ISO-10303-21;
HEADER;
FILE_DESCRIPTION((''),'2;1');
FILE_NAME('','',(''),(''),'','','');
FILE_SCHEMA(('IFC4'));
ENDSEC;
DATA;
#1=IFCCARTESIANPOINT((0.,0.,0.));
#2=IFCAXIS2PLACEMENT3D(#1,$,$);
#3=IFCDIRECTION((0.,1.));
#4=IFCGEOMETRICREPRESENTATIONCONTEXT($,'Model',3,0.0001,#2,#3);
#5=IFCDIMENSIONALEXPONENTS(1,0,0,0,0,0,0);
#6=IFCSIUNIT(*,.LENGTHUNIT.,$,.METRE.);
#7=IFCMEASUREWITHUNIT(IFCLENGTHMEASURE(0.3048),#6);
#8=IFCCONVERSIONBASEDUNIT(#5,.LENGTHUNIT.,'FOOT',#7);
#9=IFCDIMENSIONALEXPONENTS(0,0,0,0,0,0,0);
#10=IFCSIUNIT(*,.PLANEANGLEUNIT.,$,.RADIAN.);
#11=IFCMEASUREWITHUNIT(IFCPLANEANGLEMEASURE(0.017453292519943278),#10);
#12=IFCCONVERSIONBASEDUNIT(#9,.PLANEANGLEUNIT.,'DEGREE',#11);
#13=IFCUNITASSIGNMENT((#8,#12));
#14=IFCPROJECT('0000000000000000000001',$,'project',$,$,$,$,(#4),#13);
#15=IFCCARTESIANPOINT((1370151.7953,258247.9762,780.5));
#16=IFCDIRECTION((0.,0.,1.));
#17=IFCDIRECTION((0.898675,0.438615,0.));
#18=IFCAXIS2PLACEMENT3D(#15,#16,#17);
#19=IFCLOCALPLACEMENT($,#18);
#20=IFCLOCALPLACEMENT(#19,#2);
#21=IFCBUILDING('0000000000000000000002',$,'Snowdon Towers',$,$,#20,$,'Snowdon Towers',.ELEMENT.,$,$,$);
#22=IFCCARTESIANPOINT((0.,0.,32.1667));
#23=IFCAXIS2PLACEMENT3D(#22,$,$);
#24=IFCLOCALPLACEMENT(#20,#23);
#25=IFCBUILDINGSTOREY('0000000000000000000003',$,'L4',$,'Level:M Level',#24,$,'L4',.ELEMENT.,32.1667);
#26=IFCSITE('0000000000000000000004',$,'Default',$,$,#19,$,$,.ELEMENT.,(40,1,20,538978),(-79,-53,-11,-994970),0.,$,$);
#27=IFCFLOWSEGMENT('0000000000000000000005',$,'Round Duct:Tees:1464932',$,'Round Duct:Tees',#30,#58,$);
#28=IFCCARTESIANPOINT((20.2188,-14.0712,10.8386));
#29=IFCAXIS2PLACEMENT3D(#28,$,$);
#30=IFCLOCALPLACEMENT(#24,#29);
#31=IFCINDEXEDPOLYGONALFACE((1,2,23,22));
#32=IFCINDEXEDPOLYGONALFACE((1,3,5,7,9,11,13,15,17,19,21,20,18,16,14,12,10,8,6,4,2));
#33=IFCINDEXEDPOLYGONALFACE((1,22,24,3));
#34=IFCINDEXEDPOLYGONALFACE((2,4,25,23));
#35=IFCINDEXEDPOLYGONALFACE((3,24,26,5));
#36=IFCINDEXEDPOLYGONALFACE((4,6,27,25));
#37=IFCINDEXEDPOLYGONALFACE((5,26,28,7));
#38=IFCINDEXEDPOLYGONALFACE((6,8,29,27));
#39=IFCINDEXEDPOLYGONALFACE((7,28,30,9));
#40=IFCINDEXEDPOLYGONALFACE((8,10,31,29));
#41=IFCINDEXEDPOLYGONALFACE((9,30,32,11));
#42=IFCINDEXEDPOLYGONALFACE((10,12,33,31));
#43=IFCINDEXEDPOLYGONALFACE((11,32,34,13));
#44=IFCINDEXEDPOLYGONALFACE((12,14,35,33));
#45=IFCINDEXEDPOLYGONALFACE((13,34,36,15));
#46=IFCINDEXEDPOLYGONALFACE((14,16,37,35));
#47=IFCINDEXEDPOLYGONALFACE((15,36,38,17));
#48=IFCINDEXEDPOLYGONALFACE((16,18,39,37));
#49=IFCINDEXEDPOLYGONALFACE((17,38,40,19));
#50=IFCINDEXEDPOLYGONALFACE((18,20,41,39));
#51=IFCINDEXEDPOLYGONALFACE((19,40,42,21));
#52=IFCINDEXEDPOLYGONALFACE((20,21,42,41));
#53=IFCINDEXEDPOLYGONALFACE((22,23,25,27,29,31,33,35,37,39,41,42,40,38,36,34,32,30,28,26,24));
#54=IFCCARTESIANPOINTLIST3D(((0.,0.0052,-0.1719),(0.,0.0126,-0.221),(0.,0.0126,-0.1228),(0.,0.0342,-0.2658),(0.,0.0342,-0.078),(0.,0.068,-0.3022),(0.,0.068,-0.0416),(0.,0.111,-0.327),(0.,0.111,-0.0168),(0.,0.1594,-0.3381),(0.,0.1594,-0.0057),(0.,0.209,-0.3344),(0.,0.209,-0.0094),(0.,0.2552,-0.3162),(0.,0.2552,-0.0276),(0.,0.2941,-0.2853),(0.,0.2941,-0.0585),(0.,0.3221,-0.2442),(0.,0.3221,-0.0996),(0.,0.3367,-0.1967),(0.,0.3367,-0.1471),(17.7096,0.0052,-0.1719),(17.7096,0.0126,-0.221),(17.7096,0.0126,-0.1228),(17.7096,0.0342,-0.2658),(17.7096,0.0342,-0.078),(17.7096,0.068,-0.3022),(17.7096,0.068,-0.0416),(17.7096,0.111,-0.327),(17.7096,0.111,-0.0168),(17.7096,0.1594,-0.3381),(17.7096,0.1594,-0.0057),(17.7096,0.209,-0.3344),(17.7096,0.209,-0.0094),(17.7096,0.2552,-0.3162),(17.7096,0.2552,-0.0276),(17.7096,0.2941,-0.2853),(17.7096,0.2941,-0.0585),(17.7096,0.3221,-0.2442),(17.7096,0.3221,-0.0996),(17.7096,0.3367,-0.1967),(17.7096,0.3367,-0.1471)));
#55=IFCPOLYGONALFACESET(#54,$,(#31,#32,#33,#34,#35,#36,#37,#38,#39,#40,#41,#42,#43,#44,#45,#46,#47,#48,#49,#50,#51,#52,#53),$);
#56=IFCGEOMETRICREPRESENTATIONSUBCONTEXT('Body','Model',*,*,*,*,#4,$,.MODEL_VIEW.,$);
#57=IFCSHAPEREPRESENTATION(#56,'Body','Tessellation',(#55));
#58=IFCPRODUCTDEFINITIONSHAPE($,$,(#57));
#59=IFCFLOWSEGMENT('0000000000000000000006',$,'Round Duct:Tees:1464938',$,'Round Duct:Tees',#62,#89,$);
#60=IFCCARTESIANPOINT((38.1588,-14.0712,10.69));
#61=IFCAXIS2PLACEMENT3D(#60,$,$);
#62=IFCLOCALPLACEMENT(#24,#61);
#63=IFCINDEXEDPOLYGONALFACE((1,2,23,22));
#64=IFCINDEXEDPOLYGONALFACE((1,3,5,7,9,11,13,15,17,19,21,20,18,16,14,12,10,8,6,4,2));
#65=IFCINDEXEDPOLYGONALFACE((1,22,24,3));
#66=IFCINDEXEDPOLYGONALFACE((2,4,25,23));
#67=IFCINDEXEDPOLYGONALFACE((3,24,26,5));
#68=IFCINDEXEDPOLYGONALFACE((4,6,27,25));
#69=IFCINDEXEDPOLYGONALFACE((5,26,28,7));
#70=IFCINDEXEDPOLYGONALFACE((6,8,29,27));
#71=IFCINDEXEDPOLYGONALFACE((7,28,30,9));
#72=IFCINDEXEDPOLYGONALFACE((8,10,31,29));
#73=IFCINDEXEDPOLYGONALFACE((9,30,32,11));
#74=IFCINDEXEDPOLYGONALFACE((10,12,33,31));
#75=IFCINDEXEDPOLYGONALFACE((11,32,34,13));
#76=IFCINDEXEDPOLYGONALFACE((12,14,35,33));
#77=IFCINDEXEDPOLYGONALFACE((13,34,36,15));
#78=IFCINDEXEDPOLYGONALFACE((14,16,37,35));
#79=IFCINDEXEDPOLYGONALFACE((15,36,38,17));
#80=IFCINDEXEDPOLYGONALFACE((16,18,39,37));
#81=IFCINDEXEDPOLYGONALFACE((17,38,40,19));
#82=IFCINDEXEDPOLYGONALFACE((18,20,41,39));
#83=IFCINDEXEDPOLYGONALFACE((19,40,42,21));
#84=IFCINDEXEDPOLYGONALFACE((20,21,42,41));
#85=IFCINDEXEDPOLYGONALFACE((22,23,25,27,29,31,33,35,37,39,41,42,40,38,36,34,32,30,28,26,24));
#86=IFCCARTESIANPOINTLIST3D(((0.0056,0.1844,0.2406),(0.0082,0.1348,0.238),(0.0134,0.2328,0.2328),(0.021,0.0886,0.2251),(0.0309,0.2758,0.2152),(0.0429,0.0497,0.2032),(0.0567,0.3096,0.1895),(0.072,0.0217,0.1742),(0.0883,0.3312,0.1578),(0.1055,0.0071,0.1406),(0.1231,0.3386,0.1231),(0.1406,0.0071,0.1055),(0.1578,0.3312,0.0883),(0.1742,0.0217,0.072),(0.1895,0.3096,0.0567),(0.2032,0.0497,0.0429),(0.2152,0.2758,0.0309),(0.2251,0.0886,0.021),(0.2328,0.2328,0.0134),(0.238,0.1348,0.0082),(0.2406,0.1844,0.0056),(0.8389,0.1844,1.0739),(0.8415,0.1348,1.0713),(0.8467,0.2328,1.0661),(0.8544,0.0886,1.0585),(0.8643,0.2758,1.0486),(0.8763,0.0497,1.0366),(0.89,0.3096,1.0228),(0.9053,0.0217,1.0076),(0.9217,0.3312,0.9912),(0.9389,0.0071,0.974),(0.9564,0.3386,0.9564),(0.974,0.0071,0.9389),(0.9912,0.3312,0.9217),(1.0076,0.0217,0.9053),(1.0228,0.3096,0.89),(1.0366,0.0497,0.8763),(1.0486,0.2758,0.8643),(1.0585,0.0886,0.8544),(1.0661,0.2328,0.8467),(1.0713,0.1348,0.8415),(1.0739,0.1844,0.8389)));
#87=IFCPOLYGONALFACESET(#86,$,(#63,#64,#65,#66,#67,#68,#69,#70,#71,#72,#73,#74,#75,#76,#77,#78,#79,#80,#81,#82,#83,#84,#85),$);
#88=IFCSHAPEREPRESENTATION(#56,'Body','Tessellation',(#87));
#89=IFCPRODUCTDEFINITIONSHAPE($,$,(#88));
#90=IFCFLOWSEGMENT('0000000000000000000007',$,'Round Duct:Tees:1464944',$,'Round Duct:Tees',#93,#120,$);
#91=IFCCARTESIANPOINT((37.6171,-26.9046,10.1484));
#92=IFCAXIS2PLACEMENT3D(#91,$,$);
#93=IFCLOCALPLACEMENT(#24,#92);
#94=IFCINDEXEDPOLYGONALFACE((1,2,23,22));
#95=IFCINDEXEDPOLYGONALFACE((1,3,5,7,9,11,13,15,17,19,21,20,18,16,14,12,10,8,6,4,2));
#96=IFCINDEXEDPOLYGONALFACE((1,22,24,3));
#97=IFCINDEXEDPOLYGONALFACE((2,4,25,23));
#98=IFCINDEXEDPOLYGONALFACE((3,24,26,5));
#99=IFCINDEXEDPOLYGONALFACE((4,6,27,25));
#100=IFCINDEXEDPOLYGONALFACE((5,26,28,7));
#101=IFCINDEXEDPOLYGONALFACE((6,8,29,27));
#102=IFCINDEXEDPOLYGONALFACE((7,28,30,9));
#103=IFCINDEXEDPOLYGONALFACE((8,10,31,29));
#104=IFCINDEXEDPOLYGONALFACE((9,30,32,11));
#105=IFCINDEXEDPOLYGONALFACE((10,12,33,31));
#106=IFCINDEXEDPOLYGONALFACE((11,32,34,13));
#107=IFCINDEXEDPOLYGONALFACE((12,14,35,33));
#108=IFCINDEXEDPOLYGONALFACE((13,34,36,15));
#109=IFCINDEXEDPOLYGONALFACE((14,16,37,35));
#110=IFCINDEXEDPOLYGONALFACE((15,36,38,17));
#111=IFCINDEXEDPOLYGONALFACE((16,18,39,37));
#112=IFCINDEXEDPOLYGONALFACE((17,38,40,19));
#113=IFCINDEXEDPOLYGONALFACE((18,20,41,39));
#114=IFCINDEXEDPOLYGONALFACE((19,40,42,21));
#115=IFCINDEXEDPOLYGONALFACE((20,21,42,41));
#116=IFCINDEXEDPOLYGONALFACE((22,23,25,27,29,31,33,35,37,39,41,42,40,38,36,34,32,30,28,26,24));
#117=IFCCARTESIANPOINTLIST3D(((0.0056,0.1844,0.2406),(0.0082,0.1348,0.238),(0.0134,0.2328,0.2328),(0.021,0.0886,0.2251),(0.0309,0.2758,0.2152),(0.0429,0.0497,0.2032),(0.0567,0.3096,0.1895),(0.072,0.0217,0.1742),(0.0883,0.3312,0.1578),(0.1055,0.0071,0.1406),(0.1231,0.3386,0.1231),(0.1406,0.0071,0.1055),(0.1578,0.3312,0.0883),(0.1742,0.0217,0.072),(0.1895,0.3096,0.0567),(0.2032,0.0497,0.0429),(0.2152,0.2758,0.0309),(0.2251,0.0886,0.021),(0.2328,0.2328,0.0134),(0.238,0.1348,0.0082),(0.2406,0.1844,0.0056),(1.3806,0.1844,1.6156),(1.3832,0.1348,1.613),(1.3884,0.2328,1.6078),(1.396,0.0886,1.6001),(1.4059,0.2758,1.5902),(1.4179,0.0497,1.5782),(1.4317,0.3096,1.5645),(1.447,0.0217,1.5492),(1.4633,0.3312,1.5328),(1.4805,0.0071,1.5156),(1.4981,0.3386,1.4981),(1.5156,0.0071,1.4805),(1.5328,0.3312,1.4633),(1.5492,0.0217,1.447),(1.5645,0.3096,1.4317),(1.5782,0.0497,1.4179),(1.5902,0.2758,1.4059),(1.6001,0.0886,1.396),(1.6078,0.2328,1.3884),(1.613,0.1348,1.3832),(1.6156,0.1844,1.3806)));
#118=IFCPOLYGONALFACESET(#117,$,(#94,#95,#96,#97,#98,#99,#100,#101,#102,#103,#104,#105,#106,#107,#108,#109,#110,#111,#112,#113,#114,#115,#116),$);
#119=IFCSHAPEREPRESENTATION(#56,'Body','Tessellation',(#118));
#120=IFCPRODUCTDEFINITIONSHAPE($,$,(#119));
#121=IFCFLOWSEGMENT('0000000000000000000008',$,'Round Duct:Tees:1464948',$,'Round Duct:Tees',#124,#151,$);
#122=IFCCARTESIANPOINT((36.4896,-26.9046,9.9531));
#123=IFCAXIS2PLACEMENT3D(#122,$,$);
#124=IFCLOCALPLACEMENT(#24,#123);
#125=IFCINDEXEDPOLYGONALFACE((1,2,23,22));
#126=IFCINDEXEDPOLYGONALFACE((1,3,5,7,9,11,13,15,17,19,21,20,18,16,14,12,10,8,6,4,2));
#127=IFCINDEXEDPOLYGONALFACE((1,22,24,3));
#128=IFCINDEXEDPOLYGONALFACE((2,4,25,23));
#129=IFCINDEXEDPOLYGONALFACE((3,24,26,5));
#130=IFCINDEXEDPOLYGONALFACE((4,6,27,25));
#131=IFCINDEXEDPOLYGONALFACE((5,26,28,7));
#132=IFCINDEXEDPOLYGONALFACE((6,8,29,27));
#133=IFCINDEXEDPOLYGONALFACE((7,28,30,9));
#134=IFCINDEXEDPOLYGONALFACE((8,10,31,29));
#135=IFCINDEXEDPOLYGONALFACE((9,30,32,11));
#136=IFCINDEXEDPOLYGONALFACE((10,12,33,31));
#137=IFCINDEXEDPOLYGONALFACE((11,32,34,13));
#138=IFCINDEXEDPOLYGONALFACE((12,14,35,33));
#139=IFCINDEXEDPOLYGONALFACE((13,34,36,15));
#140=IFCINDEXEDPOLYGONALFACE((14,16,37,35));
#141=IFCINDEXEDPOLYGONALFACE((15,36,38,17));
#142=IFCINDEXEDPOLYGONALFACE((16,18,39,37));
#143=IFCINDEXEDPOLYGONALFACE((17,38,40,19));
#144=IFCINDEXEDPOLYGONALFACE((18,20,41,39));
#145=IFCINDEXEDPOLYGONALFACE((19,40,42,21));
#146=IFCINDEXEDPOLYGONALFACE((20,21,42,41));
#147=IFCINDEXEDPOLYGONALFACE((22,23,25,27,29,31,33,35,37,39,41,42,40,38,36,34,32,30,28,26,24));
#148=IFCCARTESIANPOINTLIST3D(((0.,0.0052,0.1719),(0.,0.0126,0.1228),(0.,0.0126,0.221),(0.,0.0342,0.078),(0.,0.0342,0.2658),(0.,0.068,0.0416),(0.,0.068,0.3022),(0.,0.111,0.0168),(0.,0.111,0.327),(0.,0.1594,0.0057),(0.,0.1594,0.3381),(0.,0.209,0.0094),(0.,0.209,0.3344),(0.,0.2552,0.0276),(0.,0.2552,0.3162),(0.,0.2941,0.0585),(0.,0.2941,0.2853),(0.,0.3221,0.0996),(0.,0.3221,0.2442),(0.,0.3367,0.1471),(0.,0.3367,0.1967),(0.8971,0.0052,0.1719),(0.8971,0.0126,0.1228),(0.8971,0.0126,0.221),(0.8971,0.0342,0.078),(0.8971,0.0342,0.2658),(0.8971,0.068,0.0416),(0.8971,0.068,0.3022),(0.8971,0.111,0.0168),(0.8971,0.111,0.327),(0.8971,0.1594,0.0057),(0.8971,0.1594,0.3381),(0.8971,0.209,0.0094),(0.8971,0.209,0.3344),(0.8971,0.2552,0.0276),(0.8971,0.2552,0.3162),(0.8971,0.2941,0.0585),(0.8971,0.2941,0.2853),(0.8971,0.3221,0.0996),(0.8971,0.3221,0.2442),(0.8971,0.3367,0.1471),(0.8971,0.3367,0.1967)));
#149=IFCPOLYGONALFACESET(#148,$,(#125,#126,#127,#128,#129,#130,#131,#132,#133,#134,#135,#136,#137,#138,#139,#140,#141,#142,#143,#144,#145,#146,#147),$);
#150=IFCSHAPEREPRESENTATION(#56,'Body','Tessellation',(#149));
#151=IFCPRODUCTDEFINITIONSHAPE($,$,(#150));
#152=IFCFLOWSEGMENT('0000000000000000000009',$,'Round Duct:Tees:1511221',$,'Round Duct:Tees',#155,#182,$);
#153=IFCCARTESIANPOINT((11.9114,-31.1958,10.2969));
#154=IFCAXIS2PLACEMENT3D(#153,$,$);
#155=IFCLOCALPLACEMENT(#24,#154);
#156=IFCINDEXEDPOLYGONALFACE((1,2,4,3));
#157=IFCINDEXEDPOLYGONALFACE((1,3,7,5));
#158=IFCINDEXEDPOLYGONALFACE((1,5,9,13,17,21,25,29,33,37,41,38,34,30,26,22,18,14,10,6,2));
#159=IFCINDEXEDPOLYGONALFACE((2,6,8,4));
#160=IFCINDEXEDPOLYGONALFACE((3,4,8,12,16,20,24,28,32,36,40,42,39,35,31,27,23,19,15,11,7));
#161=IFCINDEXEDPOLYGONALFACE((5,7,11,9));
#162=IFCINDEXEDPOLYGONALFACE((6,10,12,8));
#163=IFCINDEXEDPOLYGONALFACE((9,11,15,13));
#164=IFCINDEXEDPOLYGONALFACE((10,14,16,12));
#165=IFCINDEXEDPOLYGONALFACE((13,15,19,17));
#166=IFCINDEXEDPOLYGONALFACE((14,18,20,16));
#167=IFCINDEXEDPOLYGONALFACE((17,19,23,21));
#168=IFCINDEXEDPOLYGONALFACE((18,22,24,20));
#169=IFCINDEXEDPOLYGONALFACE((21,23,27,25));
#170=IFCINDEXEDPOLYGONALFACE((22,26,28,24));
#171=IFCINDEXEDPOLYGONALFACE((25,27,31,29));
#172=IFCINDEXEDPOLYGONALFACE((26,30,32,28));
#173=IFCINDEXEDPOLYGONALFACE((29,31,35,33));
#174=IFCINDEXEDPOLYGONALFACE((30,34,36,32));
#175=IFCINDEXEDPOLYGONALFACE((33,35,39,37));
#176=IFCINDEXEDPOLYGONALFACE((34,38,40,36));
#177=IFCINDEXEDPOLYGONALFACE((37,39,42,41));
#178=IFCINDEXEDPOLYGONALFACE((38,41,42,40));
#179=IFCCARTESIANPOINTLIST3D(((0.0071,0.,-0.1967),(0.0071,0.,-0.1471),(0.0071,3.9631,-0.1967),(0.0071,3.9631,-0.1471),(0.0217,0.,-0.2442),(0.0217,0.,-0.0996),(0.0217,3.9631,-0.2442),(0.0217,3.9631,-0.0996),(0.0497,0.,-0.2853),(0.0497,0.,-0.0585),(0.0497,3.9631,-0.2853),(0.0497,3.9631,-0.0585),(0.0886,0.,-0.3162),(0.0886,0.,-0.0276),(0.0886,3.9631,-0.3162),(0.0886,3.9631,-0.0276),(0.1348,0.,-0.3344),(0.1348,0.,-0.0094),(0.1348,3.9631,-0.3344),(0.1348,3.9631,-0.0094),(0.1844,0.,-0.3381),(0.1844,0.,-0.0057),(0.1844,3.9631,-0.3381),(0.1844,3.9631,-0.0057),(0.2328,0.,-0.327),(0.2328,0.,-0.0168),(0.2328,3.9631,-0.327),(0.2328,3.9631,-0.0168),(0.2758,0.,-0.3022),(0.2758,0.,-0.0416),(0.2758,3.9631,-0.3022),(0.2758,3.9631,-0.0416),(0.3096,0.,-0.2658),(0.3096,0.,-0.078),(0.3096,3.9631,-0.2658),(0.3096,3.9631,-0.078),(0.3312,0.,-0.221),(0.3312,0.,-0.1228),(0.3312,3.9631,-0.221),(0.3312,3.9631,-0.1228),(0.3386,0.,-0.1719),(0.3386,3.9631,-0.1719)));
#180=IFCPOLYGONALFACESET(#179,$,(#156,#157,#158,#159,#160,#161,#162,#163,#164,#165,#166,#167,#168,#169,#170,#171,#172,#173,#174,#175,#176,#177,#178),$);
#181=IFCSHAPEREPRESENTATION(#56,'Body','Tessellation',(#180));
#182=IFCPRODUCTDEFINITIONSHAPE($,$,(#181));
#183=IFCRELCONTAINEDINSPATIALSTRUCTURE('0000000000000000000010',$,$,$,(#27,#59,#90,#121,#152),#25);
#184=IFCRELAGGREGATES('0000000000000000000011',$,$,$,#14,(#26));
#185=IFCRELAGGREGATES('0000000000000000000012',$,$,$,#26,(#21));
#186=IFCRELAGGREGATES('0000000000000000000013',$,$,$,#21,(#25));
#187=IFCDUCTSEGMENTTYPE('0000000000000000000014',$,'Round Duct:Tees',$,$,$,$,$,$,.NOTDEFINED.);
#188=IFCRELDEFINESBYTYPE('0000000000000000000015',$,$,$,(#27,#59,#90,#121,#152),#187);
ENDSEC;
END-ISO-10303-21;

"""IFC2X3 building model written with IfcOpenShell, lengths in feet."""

from ifc_helpers import new_model, entity, si_unit, converted_unit, direction, frame, frame_2d, origin, origin_2d_with_axis, place, context, subcontext, project, spatial, circle, extrude, type_object, element, save


model = new_model("IFC2X3")

# Units and contexts
model_context = context("Model", 3, precision=0.0001, world=origin(), true_north=direction((0.0, 1.0)))
body_context = subcontext(model_context, "Body", "Model", "MODEL_VIEW")
ifc_project = project(units=[converted_unit("LENGTHUNIT", "FOOT", entity("IfcLengthMeasure", 0.3048), si_unit("LENGTHUNIT", "METRE"), dimensions=[1, 0, 0, 0, 0, 0, 0]), converted_unit("PLANEANGLEUNIT", "DEGREE", entity("IfcPlaneAngleMeasure", 0.017453292519943278), si_unit("PLANEANGLEUNIT", "RADIAN"), dimensions=[0, 0, 0, 0, 0, 0, 0])], contexts=[model_context])

# Site, building, storey
site_placement = place(None, frame((1370151.7953, 258247.9762, 780.5), z_axis=(0.0, 0.0, 1.0), x_axis=(0.898675, 0.438615, 0.0)))
site = spatial("IfcSite", under=ifc_project, at=site_placement, Name="Default", CompositionType="ELEMENT", RefLatitude=(40, 1, 20, 538978), RefLongitude=(-79, -53, -11, -994970), RefElevation=0.0)
building_placement = place(site_placement, origin())
building = spatial("IfcBuilding", under=site, at=building_placement, Name="Snowdon Towers", LongName="Snowdon Towers", CompositionType="ELEMENT")
storey_placement = place(building_placement, frame((0.0, 0.0, 32.1667)))
storey = spatial("IfcBuildingStorey", under=building, at=storey_placement, Name="L4", ObjectType="Level:M Level", LongName="L4", CompositionType="ELEMENT", Elevation=32.1667)

# Flow segments
duct_segment_type = type_object("IfcDuctSegmentType", Name="Round Duct:Tees", PredefinedType="NOTDEFINED")
flow_segment_1_placement = place(storey_placement, frame((20.2188, -14.0712, 10.8386)))
element("IfcFlowSegment", 1, at=flow_segment_1_placement, inside=storey, type_object=duct_segment_type, Name="Round Duct:Tees:1464932", ObjectType="Round Duct:Tees", context=body_context, shape_type="SweptSolid", body=[
    extrude(circle(Radius=0.1667, at=frame_2d((0.0, 0.0), x_axis=(1.0, 0.0))), frame((0.0, 0.1719, -0.1719), z_axis=(1.0, 0.0, 0.0), x_axis=(0.0, -1.0, 0.0)), (0.0, 0.0, 1.0), 17.7096),
])
flow_segment_2_placement = place(storey_placement, frame((38.1588, -14.0712, 10.69)))
element("IfcFlowSegment", 2, at=flow_segment_2_placement, inside=storey, type_object=duct_segment_type, Name="Round Duct:Tees:1464938", ObjectType="Round Duct:Tees", context=body_context, shape_type="SweptSolid", body=[
    extrude(circle(Radius=0.1667, at=frame_2d((0.0, 0.0), x_axis=(1.0, 0.0))), frame((0.1231, 0.1719, 0.1231), z_axis=(0.707107, 0.0, 0.707107), x_axis=(0.0, 1.0, 0.0)), (0.0, 0.0, 1.0), 1.1785),
])
flow_segment_3_placement = place(storey_placement, frame((37.6171, -26.9046, 10.1484)))
element("IfcFlowSegment", 3, at=flow_segment_3_placement, inside=storey, type_object=duct_segment_type, Name="Round Duct:Tees:1464944", ObjectType="Round Duct:Tees", context=body_context, shape_type="SweptSolid", body=[
    extrude(circle(Radius=0.1667, at=frame_2d((0.0, 0.0), x_axis=(1.0, 0.0))), frame((0.1231, 0.1719, 0.1231), z_axis=(0.707107, 0.0, 0.707107), x_axis=(0.0, 1.0, 0.0)), (0.0, 0.0, 1.0), 1.9445),
])
flow_segment_4_placement = place(storey_placement, frame((36.4896, -26.9046, 9.9531)))
element("IfcFlowSegment", 4, at=flow_segment_4_placement, inside=storey, type_object=duct_segment_type, Name="Round Duct:Tees:1464948", ObjectType="Round Duct:Tees", context=body_context, shape_type="SweptSolid", body=[
    extrude(circle(Radius=0.1667, at=origin_2d_with_axis()), frame((0.0, 0.1719, 0.1719), z_axis=(1.0, 0.0, 0.0), x_axis=(0.0, -1.0, 0.0)), (0.0, 0.0, 1.0), 0.8971),
])
flow_segment_5_placement = place(storey_placement, frame((11.9114, -31.1958, 10.2969)))
element("IfcFlowSegment", 5, at=flow_segment_5_placement, inside=storey, type_object=duct_segment_type, Name="Round Duct:Tees:1511221", ObjectType="Round Duct:Tees", context=body_context, shape_type="SweptSolid", body=[
    extrude(circle(Radius=0.1667, at=origin_2d_with_axis()), frame((0.1719, 0.0, -0.1719), z_axis=(0.0, 1.0, 0.0), x_axis=(1.0, 0.0, 0.0)), (0.0, 0.0, 1.0), 3.9631),
])

save(model, "model.ifc")
